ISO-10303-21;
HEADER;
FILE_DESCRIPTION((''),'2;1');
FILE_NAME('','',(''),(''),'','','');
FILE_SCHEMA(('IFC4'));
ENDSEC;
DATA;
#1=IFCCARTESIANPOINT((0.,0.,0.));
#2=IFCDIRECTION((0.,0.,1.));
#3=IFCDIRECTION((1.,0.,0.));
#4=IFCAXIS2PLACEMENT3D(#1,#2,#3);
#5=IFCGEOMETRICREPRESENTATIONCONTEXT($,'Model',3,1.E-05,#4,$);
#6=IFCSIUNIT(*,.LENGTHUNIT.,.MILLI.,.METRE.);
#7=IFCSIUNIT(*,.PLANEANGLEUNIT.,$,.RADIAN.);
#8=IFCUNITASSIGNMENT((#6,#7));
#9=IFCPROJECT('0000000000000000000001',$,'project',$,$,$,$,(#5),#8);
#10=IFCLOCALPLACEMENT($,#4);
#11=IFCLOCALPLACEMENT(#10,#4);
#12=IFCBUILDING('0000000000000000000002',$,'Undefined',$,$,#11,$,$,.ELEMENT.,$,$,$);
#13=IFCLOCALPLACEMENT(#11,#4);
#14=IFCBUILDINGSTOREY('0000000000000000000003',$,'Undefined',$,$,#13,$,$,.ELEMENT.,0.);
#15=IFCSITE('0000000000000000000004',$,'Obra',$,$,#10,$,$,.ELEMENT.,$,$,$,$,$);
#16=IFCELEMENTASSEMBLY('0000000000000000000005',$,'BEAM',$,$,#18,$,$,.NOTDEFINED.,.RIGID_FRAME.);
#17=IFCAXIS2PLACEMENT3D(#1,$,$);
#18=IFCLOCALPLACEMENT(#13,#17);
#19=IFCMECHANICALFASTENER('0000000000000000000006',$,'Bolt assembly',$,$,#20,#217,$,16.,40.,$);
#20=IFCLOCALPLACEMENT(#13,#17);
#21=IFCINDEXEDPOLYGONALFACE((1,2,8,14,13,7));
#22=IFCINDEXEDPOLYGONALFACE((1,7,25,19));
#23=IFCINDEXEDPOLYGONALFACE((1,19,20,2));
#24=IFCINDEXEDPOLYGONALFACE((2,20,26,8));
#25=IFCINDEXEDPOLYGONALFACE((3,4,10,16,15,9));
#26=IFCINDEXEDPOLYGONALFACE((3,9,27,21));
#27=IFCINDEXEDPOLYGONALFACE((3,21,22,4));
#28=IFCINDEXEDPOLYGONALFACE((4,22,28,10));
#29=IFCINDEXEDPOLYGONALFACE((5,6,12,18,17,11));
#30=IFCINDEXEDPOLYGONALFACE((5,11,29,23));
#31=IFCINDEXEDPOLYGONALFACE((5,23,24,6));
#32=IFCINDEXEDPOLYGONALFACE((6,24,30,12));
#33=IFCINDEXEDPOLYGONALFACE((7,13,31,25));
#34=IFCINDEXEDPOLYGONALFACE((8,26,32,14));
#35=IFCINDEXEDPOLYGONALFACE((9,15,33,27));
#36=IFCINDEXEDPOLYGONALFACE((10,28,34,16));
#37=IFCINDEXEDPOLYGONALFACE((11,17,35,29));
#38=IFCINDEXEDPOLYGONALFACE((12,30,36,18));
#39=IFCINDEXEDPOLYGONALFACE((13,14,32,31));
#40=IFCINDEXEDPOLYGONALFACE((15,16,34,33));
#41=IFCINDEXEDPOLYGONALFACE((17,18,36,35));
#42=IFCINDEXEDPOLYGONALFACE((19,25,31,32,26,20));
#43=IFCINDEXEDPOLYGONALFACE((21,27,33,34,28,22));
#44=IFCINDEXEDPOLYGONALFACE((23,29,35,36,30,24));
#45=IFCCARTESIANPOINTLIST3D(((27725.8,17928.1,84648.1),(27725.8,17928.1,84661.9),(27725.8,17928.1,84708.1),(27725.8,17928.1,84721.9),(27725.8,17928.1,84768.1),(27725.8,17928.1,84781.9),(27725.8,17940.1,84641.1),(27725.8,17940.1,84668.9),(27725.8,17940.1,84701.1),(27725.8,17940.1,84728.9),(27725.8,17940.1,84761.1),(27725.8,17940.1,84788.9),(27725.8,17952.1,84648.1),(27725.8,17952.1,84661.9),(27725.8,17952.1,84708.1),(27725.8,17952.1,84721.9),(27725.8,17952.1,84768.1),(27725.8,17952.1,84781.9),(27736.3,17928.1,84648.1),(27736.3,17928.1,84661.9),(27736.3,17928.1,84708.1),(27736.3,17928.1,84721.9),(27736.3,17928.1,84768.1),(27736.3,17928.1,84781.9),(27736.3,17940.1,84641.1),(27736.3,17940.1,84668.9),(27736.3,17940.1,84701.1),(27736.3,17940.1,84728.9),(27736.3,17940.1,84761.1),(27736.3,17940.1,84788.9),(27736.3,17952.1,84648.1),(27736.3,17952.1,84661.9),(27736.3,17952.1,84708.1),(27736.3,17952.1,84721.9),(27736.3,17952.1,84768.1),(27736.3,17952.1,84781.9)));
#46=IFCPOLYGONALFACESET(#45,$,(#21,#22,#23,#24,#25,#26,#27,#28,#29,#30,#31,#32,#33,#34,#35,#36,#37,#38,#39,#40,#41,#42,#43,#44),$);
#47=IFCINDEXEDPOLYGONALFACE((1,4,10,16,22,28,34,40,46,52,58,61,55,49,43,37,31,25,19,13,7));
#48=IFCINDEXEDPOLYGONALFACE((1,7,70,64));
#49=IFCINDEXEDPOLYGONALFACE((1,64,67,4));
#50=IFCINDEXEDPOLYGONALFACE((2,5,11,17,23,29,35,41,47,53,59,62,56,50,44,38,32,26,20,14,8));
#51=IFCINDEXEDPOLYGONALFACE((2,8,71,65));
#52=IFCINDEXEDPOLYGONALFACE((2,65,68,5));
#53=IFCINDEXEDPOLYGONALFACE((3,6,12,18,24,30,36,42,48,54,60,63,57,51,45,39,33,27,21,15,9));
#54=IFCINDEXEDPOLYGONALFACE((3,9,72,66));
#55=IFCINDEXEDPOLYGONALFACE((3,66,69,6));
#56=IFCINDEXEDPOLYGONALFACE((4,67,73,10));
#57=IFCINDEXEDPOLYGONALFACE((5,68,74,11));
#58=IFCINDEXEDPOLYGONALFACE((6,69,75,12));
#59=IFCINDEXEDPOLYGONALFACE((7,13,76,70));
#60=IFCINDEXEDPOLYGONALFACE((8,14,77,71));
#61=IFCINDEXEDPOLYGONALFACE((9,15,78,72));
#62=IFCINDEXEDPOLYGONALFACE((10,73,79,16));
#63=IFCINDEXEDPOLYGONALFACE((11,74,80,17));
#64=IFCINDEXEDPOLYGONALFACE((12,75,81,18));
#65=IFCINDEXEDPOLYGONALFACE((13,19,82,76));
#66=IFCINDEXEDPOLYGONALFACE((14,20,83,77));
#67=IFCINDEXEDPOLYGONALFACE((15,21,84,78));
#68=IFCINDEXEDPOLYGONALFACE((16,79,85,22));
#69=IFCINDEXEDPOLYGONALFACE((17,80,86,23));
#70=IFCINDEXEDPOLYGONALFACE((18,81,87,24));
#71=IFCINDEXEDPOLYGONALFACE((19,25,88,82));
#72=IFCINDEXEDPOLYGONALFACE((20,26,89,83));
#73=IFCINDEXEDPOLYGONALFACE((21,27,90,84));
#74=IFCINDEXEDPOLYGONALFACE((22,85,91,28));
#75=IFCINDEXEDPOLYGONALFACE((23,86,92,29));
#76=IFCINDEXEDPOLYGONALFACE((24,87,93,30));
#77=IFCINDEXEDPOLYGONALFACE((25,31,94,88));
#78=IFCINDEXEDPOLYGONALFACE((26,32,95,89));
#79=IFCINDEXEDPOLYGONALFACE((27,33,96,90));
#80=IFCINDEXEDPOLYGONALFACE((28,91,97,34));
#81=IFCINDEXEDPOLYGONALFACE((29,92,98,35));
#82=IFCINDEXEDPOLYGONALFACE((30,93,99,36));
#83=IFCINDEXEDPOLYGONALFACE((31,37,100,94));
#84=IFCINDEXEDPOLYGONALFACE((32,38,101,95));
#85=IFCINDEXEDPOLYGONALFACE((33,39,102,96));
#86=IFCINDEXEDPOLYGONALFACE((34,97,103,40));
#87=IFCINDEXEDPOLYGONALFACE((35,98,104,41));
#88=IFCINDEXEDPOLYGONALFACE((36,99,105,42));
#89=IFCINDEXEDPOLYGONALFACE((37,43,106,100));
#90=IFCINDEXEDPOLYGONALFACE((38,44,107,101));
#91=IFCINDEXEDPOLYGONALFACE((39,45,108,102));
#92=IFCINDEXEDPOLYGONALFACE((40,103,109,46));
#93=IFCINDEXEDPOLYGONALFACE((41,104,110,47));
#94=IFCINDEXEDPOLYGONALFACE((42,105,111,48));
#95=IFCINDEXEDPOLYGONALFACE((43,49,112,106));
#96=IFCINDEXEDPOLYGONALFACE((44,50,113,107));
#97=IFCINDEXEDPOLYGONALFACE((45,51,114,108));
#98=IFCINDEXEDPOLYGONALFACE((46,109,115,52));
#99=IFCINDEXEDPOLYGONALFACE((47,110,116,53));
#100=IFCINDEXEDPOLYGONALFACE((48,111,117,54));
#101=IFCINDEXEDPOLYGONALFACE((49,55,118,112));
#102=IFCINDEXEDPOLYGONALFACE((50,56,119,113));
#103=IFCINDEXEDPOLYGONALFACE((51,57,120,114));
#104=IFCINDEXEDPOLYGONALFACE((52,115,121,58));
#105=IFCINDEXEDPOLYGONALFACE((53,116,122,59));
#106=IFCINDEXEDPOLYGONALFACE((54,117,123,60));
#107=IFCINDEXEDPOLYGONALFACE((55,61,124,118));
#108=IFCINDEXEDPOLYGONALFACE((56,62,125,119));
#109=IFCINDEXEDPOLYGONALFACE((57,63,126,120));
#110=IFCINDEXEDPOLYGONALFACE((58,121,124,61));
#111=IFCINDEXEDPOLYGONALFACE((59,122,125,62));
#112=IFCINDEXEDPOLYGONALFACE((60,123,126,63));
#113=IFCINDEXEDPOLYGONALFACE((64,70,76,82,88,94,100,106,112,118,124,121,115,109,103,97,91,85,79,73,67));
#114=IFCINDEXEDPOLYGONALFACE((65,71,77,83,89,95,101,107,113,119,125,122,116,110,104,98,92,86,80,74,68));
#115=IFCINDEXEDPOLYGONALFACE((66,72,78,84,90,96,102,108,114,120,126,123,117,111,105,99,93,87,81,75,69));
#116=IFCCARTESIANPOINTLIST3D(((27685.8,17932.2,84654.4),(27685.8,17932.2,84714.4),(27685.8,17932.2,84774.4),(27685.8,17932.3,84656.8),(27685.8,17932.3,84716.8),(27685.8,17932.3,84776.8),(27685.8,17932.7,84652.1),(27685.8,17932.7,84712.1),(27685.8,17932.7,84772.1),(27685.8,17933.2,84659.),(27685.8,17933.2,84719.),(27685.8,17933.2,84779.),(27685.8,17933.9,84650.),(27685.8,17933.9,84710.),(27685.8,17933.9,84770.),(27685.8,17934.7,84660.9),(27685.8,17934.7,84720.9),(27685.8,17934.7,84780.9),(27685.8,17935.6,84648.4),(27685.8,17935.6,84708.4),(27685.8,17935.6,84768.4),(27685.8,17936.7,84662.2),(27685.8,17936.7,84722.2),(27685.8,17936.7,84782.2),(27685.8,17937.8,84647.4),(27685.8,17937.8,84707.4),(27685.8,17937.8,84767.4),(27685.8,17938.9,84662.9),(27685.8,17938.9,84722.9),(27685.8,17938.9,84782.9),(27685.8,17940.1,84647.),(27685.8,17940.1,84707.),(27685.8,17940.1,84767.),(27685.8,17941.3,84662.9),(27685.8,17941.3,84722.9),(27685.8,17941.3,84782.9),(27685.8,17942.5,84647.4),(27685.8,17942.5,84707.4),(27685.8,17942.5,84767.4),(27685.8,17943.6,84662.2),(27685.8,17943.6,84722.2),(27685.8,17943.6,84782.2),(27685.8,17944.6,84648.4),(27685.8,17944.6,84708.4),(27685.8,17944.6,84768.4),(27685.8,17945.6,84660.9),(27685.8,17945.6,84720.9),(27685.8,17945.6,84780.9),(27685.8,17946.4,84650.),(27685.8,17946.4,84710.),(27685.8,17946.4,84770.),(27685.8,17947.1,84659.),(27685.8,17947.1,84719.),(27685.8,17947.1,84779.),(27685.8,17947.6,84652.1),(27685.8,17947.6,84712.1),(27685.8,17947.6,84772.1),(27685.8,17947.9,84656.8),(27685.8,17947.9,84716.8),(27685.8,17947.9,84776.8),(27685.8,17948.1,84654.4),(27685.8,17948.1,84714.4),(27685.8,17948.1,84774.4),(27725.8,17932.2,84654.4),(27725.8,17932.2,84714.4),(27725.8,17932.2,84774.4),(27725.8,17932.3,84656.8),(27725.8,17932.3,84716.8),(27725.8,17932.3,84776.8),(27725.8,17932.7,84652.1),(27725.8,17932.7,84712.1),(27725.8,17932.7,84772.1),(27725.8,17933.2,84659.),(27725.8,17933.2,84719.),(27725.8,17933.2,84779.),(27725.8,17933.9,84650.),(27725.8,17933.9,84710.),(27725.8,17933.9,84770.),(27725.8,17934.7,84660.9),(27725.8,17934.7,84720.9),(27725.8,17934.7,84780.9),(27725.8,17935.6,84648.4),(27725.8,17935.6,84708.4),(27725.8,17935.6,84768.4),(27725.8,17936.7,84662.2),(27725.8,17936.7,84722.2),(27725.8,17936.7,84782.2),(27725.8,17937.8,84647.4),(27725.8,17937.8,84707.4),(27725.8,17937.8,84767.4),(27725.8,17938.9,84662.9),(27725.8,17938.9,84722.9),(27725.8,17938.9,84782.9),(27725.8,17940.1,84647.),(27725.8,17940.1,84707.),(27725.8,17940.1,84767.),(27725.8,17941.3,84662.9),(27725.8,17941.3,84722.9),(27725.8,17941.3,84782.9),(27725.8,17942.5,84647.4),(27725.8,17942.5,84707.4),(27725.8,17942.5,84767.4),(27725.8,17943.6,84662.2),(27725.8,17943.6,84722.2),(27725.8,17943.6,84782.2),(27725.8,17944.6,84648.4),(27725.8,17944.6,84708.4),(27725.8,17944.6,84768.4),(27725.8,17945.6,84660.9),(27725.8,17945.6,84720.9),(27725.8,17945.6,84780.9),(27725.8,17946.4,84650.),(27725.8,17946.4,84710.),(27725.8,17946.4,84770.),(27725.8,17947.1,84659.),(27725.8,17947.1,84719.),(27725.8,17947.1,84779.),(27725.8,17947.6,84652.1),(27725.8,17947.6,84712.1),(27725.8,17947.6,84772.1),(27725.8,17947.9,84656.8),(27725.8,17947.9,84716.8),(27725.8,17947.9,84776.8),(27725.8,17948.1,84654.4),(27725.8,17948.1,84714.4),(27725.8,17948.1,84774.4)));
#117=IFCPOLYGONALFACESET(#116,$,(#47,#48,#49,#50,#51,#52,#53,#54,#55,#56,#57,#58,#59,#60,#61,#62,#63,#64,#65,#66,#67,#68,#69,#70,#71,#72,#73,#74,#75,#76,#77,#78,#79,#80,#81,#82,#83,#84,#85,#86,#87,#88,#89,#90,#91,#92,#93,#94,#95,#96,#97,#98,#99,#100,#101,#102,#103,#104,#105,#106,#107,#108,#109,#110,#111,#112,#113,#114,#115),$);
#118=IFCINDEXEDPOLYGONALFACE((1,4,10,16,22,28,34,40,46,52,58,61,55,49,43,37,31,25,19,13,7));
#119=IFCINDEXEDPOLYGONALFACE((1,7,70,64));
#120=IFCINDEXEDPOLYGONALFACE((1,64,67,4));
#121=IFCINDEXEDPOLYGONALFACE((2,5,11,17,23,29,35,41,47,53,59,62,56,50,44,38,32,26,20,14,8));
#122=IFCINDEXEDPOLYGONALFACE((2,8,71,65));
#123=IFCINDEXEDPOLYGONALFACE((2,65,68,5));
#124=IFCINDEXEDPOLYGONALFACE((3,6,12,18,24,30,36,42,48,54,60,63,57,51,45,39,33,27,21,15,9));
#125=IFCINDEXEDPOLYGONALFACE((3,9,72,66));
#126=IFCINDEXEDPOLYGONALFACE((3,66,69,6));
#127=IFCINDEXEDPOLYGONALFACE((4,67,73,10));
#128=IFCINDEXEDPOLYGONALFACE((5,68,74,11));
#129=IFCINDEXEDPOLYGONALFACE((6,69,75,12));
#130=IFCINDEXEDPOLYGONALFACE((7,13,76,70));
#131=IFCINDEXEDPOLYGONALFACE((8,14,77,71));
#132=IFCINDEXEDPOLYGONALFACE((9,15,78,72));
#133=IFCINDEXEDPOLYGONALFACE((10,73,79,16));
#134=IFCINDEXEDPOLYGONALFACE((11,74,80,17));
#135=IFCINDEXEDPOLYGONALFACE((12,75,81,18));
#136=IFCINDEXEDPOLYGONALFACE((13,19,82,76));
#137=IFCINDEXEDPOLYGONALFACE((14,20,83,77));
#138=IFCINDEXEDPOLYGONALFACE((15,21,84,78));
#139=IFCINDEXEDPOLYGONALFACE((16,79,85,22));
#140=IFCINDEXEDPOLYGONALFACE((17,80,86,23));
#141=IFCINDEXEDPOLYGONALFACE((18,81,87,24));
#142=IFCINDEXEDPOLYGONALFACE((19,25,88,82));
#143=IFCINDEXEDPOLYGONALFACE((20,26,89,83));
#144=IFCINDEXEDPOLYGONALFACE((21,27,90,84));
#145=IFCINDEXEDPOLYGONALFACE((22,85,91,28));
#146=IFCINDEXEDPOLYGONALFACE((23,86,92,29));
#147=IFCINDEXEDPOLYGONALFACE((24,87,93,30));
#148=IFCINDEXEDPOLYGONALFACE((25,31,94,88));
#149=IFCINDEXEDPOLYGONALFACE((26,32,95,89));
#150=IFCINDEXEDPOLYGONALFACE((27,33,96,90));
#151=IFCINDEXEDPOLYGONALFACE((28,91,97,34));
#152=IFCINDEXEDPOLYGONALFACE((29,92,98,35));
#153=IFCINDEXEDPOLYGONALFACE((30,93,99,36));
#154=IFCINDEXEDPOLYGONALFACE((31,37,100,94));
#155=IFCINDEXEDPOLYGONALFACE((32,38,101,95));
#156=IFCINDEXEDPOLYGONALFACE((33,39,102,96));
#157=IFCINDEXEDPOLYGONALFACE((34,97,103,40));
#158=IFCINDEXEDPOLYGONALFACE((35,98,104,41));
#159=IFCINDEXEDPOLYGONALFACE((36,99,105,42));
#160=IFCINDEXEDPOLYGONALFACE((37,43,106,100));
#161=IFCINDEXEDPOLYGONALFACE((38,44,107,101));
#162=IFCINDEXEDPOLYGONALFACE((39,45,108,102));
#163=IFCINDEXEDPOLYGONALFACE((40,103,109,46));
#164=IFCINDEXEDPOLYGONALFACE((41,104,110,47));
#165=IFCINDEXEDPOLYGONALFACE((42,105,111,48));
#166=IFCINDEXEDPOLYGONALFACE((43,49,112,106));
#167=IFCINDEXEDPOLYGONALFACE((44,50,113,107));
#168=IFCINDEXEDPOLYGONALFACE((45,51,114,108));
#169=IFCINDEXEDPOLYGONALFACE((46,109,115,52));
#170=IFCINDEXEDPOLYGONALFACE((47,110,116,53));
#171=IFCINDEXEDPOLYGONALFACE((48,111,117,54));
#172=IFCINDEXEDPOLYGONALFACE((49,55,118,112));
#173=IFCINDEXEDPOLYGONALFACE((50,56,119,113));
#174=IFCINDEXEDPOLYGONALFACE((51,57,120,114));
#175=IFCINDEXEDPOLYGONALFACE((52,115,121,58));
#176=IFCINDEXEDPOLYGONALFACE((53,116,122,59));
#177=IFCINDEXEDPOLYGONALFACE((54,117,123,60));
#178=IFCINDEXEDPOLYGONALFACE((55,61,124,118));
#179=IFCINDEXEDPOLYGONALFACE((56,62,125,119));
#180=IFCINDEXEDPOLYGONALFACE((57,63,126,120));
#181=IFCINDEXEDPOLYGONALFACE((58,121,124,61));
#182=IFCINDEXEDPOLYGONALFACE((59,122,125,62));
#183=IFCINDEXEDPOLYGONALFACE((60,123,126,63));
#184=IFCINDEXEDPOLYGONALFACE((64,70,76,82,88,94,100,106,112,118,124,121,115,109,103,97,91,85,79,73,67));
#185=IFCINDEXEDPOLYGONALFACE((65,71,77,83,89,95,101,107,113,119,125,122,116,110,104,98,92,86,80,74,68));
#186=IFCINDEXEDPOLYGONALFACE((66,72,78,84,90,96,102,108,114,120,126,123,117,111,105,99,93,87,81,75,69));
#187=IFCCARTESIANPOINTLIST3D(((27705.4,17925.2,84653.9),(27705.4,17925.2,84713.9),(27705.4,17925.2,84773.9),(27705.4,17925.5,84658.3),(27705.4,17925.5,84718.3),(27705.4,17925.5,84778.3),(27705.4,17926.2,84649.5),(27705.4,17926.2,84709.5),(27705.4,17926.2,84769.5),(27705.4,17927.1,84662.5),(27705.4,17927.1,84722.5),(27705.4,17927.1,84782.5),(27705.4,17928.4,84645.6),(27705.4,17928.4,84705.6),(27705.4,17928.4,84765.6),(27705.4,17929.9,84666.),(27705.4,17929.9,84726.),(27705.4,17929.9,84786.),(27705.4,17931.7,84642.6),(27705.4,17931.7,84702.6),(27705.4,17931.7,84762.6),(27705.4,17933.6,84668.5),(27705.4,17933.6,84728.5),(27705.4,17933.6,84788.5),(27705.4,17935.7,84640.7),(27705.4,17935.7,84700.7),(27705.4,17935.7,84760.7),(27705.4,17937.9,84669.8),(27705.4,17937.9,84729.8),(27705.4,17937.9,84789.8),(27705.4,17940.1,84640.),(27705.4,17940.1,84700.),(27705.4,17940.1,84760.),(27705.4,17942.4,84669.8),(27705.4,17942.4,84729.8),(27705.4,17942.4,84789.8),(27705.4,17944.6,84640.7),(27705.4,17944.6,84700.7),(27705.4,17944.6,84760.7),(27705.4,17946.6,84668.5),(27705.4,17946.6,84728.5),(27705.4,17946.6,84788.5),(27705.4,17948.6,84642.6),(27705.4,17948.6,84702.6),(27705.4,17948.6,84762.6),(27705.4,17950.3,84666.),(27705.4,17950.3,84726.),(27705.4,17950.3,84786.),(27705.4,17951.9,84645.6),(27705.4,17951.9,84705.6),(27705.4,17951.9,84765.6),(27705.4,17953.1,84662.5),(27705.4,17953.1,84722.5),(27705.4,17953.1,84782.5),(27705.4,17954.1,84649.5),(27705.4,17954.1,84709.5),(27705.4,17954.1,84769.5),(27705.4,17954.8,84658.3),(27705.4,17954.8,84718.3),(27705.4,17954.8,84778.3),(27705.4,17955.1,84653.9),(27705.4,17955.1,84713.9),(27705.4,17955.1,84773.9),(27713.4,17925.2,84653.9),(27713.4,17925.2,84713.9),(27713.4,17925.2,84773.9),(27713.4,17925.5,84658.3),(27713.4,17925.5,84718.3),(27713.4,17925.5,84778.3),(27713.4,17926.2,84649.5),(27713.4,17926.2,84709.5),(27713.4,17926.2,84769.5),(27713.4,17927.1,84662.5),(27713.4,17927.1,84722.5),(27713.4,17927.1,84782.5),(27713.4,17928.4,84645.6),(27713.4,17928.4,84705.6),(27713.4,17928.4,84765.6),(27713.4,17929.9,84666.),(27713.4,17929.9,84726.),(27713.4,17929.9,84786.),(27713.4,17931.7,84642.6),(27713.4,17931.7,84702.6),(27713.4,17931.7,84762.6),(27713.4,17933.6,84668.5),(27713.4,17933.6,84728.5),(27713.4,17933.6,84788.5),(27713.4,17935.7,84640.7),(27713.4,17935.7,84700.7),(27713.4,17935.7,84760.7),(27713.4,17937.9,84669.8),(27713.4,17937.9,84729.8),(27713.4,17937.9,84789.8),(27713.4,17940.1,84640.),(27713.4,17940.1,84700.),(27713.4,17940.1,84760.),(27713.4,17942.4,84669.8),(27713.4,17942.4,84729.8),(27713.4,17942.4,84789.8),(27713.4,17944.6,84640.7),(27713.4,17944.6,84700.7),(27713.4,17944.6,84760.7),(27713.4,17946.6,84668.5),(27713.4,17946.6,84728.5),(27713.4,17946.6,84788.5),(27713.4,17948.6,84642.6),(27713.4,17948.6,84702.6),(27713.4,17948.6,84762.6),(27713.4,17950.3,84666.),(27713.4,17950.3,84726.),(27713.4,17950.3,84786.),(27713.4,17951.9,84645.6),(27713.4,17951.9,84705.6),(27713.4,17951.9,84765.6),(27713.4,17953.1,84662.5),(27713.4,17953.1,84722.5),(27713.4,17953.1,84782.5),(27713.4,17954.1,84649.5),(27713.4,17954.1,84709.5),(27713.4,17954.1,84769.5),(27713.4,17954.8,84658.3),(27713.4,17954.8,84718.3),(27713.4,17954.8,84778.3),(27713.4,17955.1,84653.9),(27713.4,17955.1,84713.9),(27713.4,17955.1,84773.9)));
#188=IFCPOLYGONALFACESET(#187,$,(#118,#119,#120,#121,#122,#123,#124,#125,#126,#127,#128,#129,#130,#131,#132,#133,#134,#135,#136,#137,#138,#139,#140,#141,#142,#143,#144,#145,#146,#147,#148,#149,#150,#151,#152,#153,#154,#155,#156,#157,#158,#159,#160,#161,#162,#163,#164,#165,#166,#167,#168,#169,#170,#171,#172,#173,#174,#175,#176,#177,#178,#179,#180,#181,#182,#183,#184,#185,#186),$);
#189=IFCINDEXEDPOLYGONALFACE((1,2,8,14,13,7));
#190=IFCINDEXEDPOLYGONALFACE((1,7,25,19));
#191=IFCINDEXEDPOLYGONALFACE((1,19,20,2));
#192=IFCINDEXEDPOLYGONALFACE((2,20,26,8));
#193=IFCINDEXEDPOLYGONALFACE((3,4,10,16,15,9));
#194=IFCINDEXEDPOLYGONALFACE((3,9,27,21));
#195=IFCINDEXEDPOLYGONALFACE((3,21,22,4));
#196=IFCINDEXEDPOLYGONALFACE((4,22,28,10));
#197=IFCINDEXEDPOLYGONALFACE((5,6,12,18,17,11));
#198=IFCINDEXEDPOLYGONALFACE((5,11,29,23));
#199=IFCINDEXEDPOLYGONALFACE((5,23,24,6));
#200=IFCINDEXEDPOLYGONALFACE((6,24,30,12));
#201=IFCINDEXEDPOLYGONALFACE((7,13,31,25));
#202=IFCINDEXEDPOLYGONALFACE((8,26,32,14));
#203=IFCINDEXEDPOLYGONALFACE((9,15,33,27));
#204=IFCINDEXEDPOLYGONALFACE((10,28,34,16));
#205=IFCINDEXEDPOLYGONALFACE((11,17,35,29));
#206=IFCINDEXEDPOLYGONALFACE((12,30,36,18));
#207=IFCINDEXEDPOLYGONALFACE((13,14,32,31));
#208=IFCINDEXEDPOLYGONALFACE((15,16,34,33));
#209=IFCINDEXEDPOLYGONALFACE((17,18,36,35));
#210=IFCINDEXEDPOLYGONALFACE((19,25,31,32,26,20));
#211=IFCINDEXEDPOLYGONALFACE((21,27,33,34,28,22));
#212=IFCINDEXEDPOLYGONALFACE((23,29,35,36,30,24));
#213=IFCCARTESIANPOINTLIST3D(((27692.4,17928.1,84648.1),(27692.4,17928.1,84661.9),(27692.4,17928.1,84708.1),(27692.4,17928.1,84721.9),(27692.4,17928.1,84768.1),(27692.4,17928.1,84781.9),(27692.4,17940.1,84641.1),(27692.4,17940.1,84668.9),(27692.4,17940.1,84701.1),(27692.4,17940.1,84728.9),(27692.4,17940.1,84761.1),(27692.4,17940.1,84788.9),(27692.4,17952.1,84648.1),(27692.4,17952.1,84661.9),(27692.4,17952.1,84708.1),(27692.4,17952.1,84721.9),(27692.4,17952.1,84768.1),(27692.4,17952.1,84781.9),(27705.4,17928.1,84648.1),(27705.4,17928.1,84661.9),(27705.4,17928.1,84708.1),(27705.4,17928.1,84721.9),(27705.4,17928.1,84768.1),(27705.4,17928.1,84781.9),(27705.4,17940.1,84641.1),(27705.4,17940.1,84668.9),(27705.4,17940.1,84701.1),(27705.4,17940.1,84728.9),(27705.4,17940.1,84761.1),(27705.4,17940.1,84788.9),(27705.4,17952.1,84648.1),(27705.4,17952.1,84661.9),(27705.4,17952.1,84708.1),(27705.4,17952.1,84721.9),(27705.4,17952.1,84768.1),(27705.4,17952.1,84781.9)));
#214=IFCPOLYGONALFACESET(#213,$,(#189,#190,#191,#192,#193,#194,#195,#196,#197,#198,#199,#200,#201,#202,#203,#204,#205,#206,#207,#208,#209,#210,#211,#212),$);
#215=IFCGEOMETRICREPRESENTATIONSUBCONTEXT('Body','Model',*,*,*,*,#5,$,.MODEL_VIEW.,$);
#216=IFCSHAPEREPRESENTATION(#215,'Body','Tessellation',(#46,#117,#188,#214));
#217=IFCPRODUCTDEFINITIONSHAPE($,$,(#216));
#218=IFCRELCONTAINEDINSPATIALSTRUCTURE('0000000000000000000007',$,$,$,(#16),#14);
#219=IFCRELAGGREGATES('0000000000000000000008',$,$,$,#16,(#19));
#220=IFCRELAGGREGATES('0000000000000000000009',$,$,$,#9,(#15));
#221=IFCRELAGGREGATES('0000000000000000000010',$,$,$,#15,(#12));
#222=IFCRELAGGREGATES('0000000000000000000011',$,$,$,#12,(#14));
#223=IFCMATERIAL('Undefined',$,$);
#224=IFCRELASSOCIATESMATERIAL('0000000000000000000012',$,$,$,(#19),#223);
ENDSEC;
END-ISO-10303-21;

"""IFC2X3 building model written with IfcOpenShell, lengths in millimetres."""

from ifc_helpers import new_model, si_unit, frame, origin_with_axes, origin_2d_with_axis, place, context, subcontext, project, spatial, polyline, circle, outline, extrude, source, transform, mapped, material, element, aggregate, save


model = new_model("IFC2X3")

# Units and contexts
model_context = context("Model", 3, precision=1e-05, world=origin_with_axes())
body_context = subcontext(model_context, "Body", "Model", "MODEL_VIEW")
ifc_project = project(units=[si_unit("LENGTHUNIT", "METRE", prefix="MILLI"), si_unit("PLANEANGLEUNIT", "RADIAN")], contexts=[model_context])

# Site, building, storey
site_placement = place(None, origin_with_axes())
site = spatial("IfcSite", under=ifc_project, at=site_placement, Name="Obra", CompositionType="ELEMENT")
building_placement = place(site_placement, origin_with_axes())
building = spatial("IfcBuilding", under=site, at=building_placement, Name="Undefined", CompositionType="ELEMENT")
storey_placement = place(building_placement, origin_with_axes())
storey = spatial("IfcBuildingStorey", under=building, at=storey_placement, Name="Undefined", CompositionType="ELEMENT", Elevation=0.0)

# Element assembly, mechanical fastener
ifc_material_1 = material(Name="Undefined")
assembly_1_placement = place(storey_placement, origin_with_axes())
assembly_1 = element("IfcElementAssembly", 1, at=assembly_1_placement, inside=storey, Name="BEAM", AssemblyPlace="NOTDEFINED", PredefinedType="RIGID_FRAME")
shared_shape_1 = source(origin_with_axes(), body_context, "Body", "SweptSolid", [
    extrude(outline(polyline([(13.9, 0.0), (6.9, 12.0), (-6.9, 12.0), (-13.9, 0.0), (-6.9, -12.0), (6.9, -12.0), (13.9, 0.0)])), frame((0.0, -19.7, 0.0), z_axis=(0.0, 1.0, 0.0), x_axis=(1.0, 0.0, 0.0)), (0.0, 0.0, 1.0), 10.6),
    extrude(circle(Radius=8.0, at=origin_2d_with_axis()), frame((0.0, -9.1, 0.0), z_axis=(0.0, 1.0, 0.0), x_axis=(1.0, 0.0, 0.0)), (0.0, 0.0, 1.0), 40.0),
    extrude(circle(Radius=15.0, at=origin_2d_with_axis()), frame((0.0, 3.3, 0.0), z_axis=(0.0, 1.0, 0.0), x_axis=(1.0, 0.0, 0.0)), (0.0, 0.0, 1.0), 8.0),
    extrude(outline(polyline([(13.9, 0.0), (6.9, 12.0), (-6.9, 12.0), (-13.9, 0.0), (-6.9, -12.0), (6.9, -12.0), (13.9, 0.0)])), frame((0.0, 11.3, 0.0), z_axis=(0.0, 1.0, 0.0), x_axis=(1.0, 0.0, 0.0)), (0.0, 0.0, 1.0), 13.0),
])
mechanical_fastener_1_placement = place(assembly_1_placement, frame((27716.7, 17890.1, 84835.0), z_axis=(0.0, 1.0, 0.0), x_axis=(0.0, 0.0, -1.0)))
mechanical_fastener_1 = element("IfcMechanicalFastener", 2, at=mechanical_fastener_1_placement, material=ifc_material_1, Name="Bolt assembly", NominalDiameter=16.0, NominalLength=40.0, context=body_context, shape_type="MappedRepresentation", body=[
    mapped(shared_shape_1, transform((60.0, 0.0, 50.0))),
    mapped(shared_shape_1, transform((120.0, 0.0, 50.0))),
    mapped(shared_shape_1, transform((180.0, 0.0, 50.0))),
])

aggregate(assembly_1, [mechanical_fastener_1])

save(model, "model.ifc")
